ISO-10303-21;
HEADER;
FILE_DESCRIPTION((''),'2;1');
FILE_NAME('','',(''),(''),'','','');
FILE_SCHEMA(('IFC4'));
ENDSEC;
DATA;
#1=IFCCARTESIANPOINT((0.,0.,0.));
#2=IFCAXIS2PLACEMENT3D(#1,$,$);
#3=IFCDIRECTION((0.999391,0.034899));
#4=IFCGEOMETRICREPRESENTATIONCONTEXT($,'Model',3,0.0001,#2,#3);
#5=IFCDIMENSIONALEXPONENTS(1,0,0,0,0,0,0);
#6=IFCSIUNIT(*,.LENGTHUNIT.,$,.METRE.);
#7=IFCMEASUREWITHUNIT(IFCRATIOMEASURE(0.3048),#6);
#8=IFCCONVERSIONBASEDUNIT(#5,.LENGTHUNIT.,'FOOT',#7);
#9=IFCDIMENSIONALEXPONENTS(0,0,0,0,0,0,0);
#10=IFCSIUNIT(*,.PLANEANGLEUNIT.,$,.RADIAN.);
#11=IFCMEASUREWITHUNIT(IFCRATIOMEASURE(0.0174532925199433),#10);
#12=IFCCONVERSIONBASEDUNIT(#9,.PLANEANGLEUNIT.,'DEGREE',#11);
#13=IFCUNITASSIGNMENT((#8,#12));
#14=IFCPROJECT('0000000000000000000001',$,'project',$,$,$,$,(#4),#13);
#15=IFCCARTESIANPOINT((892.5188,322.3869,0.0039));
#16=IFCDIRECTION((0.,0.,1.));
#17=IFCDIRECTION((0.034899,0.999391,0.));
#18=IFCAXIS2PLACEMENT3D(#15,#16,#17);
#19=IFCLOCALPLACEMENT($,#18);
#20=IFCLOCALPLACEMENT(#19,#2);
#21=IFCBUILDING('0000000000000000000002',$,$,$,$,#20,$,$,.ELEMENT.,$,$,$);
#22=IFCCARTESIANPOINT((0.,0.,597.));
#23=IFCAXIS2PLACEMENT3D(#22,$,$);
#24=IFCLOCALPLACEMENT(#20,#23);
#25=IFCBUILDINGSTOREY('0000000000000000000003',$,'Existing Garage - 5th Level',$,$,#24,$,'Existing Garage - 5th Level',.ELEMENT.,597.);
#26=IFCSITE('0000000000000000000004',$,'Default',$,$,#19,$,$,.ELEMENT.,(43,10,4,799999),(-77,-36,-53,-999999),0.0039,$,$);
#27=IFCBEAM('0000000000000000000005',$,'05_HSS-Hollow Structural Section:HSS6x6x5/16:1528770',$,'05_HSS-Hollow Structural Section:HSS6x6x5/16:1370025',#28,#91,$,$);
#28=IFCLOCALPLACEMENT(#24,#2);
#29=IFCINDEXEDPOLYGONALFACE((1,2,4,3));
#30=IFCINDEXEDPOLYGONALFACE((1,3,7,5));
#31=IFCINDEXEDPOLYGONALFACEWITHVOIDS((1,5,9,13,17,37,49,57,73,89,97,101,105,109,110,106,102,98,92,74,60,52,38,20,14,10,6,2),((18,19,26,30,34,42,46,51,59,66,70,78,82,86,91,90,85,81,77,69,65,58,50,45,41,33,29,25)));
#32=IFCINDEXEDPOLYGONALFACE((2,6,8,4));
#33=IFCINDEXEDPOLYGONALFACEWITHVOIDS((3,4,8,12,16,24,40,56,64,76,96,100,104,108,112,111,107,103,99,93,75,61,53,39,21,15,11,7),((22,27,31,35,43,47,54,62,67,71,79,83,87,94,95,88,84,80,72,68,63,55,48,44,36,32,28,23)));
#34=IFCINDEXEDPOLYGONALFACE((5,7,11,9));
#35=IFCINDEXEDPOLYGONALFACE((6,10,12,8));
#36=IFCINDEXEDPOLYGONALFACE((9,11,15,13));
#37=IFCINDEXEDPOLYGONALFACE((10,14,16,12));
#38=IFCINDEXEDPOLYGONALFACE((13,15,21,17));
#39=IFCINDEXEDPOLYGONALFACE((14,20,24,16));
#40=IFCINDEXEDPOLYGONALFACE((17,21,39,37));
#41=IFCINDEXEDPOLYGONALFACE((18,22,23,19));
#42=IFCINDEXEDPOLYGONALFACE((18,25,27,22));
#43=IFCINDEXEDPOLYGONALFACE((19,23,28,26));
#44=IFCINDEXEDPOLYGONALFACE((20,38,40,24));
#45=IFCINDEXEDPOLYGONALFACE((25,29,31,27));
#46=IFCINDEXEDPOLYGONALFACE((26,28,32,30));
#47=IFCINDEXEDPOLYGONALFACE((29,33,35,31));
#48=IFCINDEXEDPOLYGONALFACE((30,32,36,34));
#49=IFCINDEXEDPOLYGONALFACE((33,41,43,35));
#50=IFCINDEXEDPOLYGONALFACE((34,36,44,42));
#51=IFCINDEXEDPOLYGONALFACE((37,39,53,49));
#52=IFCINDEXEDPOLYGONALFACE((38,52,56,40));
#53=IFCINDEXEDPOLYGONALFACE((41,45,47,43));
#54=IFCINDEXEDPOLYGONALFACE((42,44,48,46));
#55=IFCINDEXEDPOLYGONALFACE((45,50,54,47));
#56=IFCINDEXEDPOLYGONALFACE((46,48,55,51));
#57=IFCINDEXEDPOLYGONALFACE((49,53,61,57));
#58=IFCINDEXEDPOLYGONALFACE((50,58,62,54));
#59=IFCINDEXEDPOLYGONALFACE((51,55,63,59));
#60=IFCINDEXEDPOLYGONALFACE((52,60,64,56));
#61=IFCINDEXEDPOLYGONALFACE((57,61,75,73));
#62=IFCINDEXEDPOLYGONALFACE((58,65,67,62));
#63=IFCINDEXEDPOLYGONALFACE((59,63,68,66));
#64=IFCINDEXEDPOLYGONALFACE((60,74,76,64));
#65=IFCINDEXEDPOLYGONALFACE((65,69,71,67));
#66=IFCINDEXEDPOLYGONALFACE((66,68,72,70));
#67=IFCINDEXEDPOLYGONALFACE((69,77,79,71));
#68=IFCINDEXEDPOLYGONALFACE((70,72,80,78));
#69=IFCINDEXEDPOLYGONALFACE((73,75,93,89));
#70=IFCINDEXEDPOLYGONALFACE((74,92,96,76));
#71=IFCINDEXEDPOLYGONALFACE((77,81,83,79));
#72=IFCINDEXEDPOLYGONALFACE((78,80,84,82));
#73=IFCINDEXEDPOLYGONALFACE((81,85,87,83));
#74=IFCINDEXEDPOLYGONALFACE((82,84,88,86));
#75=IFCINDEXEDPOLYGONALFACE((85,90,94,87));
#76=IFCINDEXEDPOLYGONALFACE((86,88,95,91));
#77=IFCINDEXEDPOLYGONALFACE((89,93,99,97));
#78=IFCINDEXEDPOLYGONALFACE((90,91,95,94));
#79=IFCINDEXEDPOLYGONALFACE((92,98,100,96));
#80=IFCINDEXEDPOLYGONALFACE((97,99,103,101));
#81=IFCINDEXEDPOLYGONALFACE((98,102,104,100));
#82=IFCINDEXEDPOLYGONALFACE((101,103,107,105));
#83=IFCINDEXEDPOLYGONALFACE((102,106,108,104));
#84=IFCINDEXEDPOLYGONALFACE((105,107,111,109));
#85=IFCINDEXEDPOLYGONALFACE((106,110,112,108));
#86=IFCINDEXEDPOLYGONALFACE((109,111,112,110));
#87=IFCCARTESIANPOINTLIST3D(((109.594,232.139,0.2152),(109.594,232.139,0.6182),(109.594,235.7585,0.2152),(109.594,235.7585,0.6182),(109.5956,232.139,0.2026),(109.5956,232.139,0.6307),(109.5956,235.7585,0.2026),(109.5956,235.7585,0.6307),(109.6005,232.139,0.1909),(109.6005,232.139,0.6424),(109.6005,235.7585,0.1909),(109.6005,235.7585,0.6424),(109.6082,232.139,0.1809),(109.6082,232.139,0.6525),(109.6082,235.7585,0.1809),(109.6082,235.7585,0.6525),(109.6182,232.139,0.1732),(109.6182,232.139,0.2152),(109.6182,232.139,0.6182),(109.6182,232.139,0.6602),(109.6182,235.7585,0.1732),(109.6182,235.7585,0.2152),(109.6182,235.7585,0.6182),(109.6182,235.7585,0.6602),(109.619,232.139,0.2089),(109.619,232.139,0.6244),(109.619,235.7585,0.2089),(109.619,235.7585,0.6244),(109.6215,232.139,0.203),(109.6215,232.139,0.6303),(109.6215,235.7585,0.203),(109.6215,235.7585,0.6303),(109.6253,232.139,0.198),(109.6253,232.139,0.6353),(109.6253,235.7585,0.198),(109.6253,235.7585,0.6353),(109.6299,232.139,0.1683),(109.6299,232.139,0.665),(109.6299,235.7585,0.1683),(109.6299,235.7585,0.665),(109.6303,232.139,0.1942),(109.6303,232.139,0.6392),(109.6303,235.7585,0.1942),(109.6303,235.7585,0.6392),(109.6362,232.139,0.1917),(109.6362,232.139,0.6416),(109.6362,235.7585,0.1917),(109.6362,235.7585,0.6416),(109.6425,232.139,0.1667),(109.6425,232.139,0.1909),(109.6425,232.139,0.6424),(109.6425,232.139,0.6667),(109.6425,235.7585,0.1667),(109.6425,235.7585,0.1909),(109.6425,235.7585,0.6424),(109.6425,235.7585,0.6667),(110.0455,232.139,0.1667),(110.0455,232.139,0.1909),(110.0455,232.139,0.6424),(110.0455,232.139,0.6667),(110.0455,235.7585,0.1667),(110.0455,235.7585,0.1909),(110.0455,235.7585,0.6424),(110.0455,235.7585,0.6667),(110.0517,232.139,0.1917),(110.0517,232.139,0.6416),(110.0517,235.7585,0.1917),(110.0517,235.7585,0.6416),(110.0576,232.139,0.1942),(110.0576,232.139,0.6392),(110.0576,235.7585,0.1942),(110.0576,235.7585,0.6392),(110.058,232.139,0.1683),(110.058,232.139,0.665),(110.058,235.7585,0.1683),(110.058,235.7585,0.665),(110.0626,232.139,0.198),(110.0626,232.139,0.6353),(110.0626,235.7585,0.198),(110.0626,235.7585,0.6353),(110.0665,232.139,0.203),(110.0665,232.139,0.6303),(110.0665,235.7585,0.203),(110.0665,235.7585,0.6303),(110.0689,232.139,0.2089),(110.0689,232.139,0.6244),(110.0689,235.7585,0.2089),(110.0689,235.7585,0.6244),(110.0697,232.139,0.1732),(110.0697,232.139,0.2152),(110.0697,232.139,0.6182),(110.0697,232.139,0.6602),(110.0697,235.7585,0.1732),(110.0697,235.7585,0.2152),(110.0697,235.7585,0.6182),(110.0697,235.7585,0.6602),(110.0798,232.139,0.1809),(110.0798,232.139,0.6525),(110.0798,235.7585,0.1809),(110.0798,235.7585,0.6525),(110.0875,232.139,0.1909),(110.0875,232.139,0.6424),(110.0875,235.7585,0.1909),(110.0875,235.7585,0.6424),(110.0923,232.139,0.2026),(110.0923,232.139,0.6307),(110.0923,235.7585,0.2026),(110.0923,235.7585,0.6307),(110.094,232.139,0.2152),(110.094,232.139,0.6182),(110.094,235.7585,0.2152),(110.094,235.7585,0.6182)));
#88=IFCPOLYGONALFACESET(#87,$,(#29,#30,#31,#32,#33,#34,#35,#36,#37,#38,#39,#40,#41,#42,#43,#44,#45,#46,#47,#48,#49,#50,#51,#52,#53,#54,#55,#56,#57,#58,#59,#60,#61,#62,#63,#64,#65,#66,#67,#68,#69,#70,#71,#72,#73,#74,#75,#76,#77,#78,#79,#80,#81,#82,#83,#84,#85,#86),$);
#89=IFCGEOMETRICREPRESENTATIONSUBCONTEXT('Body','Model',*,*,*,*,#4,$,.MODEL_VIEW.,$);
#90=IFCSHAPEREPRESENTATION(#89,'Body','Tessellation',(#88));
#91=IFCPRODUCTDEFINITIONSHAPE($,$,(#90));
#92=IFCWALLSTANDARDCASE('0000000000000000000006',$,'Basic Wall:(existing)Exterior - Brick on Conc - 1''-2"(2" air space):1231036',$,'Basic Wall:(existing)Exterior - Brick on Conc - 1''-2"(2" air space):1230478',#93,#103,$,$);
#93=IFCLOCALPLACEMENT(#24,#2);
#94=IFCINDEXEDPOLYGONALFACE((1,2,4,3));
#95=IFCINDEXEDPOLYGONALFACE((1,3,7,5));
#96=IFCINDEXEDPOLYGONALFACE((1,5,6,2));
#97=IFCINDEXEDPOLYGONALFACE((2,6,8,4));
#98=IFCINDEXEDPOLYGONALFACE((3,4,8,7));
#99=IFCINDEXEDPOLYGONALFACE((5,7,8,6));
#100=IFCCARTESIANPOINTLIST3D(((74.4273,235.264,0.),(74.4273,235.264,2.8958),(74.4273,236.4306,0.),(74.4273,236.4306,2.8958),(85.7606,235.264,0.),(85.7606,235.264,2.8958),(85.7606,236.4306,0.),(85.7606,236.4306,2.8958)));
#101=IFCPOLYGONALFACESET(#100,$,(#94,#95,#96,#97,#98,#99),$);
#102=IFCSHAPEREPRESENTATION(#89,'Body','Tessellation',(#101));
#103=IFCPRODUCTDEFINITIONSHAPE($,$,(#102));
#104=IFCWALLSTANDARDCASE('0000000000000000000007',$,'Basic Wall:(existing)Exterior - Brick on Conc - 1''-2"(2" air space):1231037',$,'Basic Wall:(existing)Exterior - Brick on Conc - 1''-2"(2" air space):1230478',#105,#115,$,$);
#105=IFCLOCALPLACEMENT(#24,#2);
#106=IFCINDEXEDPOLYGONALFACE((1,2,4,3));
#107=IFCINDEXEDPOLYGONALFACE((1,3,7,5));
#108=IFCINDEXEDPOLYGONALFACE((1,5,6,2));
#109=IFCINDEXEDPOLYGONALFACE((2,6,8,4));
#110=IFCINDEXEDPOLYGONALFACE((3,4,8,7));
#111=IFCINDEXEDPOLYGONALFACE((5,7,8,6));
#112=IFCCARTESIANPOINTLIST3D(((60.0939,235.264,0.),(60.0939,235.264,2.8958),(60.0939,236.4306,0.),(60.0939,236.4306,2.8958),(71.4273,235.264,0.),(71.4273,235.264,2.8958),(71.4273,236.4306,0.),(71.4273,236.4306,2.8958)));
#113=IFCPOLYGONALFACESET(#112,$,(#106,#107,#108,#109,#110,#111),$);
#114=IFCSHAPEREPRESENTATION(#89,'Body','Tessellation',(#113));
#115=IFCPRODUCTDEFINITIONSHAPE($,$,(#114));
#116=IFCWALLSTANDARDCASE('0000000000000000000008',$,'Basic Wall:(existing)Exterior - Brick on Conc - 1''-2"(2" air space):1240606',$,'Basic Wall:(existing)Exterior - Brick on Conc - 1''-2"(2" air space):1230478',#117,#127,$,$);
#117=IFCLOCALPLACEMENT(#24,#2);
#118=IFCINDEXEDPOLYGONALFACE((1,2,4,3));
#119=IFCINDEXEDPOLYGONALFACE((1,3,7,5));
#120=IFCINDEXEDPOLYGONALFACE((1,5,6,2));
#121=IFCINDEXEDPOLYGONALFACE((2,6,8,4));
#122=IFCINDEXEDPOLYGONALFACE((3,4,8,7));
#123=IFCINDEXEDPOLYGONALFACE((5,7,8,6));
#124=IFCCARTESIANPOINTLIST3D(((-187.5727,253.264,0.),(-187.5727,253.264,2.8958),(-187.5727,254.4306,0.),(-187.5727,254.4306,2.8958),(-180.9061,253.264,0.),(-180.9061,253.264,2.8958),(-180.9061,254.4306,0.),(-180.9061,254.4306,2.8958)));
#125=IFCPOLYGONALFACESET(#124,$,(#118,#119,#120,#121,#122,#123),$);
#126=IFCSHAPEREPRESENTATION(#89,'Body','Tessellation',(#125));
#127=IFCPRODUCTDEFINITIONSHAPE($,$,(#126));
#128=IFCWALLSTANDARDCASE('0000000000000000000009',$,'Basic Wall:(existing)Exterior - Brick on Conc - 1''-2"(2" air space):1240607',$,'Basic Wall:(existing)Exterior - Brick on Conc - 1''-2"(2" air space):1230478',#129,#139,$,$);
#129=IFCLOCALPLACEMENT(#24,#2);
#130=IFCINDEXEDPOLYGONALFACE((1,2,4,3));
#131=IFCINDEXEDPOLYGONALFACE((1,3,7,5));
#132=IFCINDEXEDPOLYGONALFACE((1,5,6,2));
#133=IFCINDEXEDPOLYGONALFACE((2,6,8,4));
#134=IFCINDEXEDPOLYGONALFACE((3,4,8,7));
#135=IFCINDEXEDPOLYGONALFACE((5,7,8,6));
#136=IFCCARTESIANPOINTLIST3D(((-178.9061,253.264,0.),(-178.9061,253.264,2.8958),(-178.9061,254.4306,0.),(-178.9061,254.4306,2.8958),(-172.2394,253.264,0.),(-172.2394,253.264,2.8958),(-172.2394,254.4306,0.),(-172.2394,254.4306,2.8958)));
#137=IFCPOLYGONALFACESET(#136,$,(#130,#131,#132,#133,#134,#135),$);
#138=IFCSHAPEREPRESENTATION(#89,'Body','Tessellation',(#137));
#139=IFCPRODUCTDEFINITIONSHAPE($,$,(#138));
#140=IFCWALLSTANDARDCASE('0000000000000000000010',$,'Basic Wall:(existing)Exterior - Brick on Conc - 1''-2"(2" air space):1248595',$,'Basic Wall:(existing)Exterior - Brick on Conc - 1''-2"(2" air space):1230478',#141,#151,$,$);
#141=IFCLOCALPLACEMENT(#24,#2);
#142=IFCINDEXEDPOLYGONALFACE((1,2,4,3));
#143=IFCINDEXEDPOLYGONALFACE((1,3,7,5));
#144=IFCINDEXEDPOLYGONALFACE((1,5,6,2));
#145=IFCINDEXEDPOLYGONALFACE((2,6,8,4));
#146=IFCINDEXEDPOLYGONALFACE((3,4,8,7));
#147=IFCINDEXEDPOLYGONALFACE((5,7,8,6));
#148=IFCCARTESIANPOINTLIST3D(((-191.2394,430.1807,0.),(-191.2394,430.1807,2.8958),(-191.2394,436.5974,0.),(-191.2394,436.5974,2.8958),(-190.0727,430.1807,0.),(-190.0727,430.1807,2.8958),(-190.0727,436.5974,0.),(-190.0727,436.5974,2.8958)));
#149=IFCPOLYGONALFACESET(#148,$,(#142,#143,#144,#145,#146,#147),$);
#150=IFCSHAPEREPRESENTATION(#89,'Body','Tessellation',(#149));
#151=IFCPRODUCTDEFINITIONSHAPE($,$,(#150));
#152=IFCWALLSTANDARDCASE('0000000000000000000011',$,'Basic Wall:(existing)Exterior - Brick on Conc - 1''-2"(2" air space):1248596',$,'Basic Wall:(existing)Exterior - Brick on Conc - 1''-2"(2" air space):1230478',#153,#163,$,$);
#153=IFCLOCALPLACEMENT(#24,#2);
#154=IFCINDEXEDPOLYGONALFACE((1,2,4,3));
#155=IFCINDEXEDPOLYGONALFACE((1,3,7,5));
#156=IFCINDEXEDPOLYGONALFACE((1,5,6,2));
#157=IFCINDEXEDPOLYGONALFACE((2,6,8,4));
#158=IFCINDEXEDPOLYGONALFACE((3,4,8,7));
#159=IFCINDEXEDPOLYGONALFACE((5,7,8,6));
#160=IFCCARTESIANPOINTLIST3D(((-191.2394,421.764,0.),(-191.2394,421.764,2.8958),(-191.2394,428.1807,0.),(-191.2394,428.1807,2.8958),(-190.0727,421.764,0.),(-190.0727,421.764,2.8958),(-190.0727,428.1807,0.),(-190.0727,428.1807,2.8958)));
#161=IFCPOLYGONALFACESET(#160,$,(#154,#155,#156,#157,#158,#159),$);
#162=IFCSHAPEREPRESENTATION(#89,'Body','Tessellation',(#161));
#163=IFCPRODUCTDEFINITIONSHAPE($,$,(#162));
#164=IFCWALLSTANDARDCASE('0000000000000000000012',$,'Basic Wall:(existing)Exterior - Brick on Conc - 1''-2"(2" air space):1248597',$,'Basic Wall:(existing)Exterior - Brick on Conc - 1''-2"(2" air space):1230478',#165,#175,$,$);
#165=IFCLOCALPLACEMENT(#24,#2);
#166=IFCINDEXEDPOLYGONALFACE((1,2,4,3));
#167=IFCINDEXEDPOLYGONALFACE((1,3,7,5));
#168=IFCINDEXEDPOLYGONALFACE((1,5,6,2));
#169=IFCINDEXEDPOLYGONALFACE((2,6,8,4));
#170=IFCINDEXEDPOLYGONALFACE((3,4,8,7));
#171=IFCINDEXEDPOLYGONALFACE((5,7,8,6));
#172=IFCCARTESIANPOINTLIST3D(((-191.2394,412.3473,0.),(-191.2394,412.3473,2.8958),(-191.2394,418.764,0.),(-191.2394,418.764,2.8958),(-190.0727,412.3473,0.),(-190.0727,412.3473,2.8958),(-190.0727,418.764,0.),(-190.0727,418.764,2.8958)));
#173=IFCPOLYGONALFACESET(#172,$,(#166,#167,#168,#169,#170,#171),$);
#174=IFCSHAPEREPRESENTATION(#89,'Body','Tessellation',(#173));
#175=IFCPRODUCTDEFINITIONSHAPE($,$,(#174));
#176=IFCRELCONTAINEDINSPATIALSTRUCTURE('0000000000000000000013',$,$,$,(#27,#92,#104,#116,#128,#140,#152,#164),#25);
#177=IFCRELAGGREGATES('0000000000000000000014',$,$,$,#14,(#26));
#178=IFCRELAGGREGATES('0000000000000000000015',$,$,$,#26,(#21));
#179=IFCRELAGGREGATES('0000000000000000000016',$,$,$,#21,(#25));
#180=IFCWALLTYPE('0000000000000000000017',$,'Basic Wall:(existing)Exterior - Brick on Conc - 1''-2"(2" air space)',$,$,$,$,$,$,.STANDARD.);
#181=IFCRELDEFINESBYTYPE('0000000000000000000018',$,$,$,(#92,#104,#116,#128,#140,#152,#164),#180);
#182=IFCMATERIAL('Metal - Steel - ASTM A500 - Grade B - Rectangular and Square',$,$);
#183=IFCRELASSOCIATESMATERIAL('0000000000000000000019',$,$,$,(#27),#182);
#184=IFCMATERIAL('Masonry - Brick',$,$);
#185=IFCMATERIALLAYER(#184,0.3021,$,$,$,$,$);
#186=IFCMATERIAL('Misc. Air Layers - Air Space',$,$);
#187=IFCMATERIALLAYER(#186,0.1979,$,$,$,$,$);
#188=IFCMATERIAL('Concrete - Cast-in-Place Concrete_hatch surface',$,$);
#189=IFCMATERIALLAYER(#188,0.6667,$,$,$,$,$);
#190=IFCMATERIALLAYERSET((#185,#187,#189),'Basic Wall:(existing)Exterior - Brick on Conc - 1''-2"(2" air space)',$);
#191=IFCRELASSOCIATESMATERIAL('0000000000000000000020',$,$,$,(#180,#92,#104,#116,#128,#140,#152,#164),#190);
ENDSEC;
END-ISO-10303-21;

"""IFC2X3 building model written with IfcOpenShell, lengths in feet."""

from ifc_helpers import new_model, entity, si_unit, converted_unit, direction, frame, frame_2d, origin, place, context, subcontext, project, spatial, polyline, circle_curve, parameter, trimmed, segment, composite_curve, rectangle, outline, extrude, material, layer, layer_set, layer_usage, type_object, element, save


model = new_model("IFC2X3")

# Units and contexts
model_context = context("Model", 3, precision=0.0001, world=origin(), true_north=direction((0.999391, 0.034899)))
body_context = subcontext(model_context, "Body", "Model", "MODEL_VIEW")
ifc_project = project(units=[converted_unit("LENGTHUNIT", "FOOT", entity("IfcRatioMeasure", 0.3048), si_unit("LENGTHUNIT", "METRE"), dimensions=[1, 0, 0, 0, 0, 0, 0]), converted_unit("PLANEANGLEUNIT", "DEGREE", entity("IfcRatioMeasure", 0.0174532925199433), si_unit("PLANEANGLEUNIT", "RADIAN"), dimensions=[0, 0, 0, 0, 0, 0, 0])], contexts=[model_context])

# Site, building, storey
site_placement = place(None, frame((892.5188, 322.3869, 0.0039), z_axis=(0.0, 0.0, 1.0), x_axis=(0.034899, 0.999391, 0.0)))
site = spatial("IfcSite", under=ifc_project, at=site_placement, Name="Default", CompositionType="ELEMENT", RefLatitude=(43, 10, 4, 799999), RefLongitude=(-77, -36, -53, -999999), RefElevation=0.0039)
building_placement = place(site_placement, origin())
building = spatial("IfcBuilding", under=site, at=building_placement, CompositionType="ELEMENT")
storey_placement = place(building_placement, frame((0.0, 0.0, 597.0)))
storey = spatial("IfcBuildingStorey", under=building, at=storey_placement, Name="Existing Garage - 5th Level", LongName="Existing Garage - 5th Level", CompositionType="ELEMENT", Elevation=597.0)

# Beam
ifc_material_1 = material(Name="Metal - Steel - ASTM A500 - Grade B - Rectangular and Square")
beam_1_placement = place(storey_placement, frame((109.844, 231.8473, 0.6667), z_axis=(0.0, 0.0, 1.0), x_axis=(0.0, 1.0, 0.0)))
element("IfcBeam", 1, at=beam_1_placement, inside=storey, material=ifc_material_1, Name="05_HSS-Hollow Structural Section:HSS6x6x5/16:1528770", ObjectType="05_HSS-Hollow Structural Section:HSS6x6x5/16:1370025", context=body_context, shape_type="SweptSolid", body=[
    extrude(outline(composite_curve([segment(trimmed(circle_curve(frame_2d((-0.2015, -0.2015), x_axis=(1.0, 0.0)), 0.0485), [parameter(180.0)], [parameter(270.0)], True, "PARAMETER"), True, "CONTINUOUS"), segment(polyline([(-0.2015, -0.25), (0.2015, -0.25)]), True, "CONTINUOUS"), segment(trimmed(circle_curve(frame_2d((0.2015, -0.2015), x_axis=(1.0, 0.0)), 0.0485), [parameter(270.0)], [parameter(0.0)], True, "PARAMETER"), True, "CONTINUOUS"), segment(polyline([(0.25, -0.2015), (0.25, 0.2015)]), True, "CONTINUOUS"), segment(trimmed(circle_curve(frame_2d((0.2015, 0.2015), x_axis=(1.0, 0.0)), 0.0485), [parameter(360.0)], [parameter(90.0)], True, "PARAMETER"), True, "CONTINUOUS"), segment(polyline([(0.2015, 0.25), (-0.2015, 0.25)]), True, "CONTINUOUS"), segment(trimmed(circle_curve(frame_2d((-0.2015, 0.2015), x_axis=(1.0, 0.0)), 0.0485), [parameter(90.0)], [parameter(180.0)], True, "PARAMETER"), True, "CONTINUOUS"), segment(polyline([(-0.25, 0.2015), (-0.25, -0.2015)]), True, "CONTINUOUS")], self_intersect=False), holes=[composite_curve([segment(polyline([(0.2015, -0.2257), (-0.2015, -0.2257)]), True, "CONTINUOUS"), segment(trimmed(circle_curve(frame_2d((-0.2015, -0.2015), x_axis=(1.0, 0.0)), 0.0243), [parameter(180.0)], [parameter(270.0)], True, "PARAMETER"), False, "CONTINUOUS"), segment(polyline([(-0.2257, -0.2015), (-0.2257, 0.2015)]), True, "CONTINUOUS"), segment(trimmed(circle_curve(frame_2d((-0.2015, 0.2015), x_axis=(1.0, 0.0)), 0.0243), [parameter(90.0)], [parameter(180.0)], True, "PARAMETER"), False, "CONTINUOUS"), segment(polyline([(-0.2015, 0.2258), (0.2015, 0.2258)]), True, "CONTINUOUS"), segment(trimmed(circle_curve(frame_2d((0.2015, 0.2015), x_axis=(1.0, 0.0)), 0.0243), [parameter(0.0)], [parameter(90.0)], True, "PARAMETER"), False, "CONTINUOUS"), segment(polyline([(0.2258, 0.2015), (0.2258, -0.2015)]), True, "CONTINUOUS"), segment(trimmed(circle_curve(frame_2d((0.2015, -0.2015), x_axis=(1.0, 0.0)), 0.0243), [parameter(270.0)], [parameter(0.0)], True, "PARAMETER"), False, "CONTINUOUS")], self_intersect=False)]), frame((0.2917, 0.0, -0.25), z_axis=(1.0, 0.0, 0.0), x_axis=(0.0, -1.0, 0.0)), (0.0, 0.0, 1.0), 3.6195),
])

# Walls
ifc_material_2 = material(Name="Masonry - Brick")
ifc_layer_1 = layer(ifc_material_2, 0.3021)
ifc_material_3 = material(Name="Misc. Air Layers - Air Space")
ifc_layer_2 = layer(ifc_material_3, 0.1979)
ifc_material_4 = material(Name="Concrete - Cast-in-Place Concrete_hatch surface")
ifc_layer_3 = layer(ifc_material_4, 0.6667)
ifc_layer_set_1 = layer_set([ifc_layer_1, ifc_layer_2, ifc_layer_3], Name="Basic Wall:(existing)Exterior - Brick on Conc - 1'-2\"(2\" air space)")
ifc_layer_usage_1 = layer_usage(ifc_layer_set_1, "AXIS2", "POSITIVE", -0.5833)
wall_type_1 = type_object("IfcWallType", Name="Basic Wall:(existing)Exterior - Brick on Conc - 1'-2\"(2\" air space)", PredefinedType="STANDARD", material=ifc_layer_set_1)
wall_1_placement = place(storey_placement, frame((74.4273, 235.8473, 0.0)))
element("IfcWallStandardCase", 2, at=wall_1_placement, inside=storey, type_object=wall_type_1, material=ifc_layer_usage_1, Name="Basic Wall:(existing)Exterior - Brick on Conc - 1'-2\"(2\" air space):1231036", ObjectType="Basic Wall:(existing)Exterior - Brick on Conc - 1'-2\"(2\" air space):1230478", context=body_context, shape_type="SweptSolid", body=[
    extrude(rectangle(XDim=11.3333, YDim=1.1667, at=frame_2d((5.6667, 0.0), x_axis=(-1.0, 0.0))), origin(), (0.0, 0.0, 1.0), 2.8958),
])
ifc_layer_usage_2 = layer_usage(ifc_layer_set_1, "AXIS2", "POSITIVE", -0.5833)
wall_2_placement = place(storey_placement, frame((60.0939, 235.8473, 0.0)))
element("IfcWallStandardCase", 3, at=wall_2_placement, inside=storey, type_object=wall_type_1, material=ifc_layer_usage_2, Name="Basic Wall:(existing)Exterior - Brick on Conc - 1'-2\"(2\" air space):1231037", ObjectType="Basic Wall:(existing)Exterior - Brick on Conc - 1'-2\"(2\" air space):1230478", context=body_context, shape_type="SweptSolid", body=[
    extrude(rectangle(XDim=11.3334, YDim=1.1667, at=frame_2d((5.6667, 0.0), x_axis=(-1.0, 0.0))), origin(), (0.0, 0.0, 1.0), 2.8958),
])
ifc_layer_usage_3 = layer_usage(ifc_layer_set_1, "AXIS2", "POSITIVE", -0.5833)
wall_3_placement = place(storey_placement, frame((-187.5727, 253.8473, 0.0)))
element("IfcWallStandardCase", 4, at=wall_3_placement, inside=storey, type_object=wall_type_1, material=ifc_layer_usage_3, Name="Basic Wall:(existing)Exterior - Brick on Conc - 1'-2\"(2\" air space):1240606", ObjectType="Basic Wall:(existing)Exterior - Brick on Conc - 1'-2\"(2\" air space):1230478", context=body_context, shape_type="SweptSolid", body=[
    extrude(rectangle(XDim=6.6667, YDim=1.1667, at=frame_2d((3.3333, 0.0), x_axis=(-1.0, 0.0))), origin(), (0.0, 0.0, 1.0), 2.8958),
])
ifc_layer_usage_4 = layer_usage(ifc_layer_set_1, "AXIS2", "POSITIVE", -0.5833)
wall_4_placement = place(storey_placement, frame((-178.9061, 253.8473, 0.0)))
element("IfcWallStandardCase", 5, at=wall_4_placement, inside=storey, type_object=wall_type_1, material=ifc_layer_usage_4, Name="Basic Wall:(existing)Exterior - Brick on Conc - 1'-2\"(2\" air space):1240607", ObjectType="Basic Wall:(existing)Exterior - Brick on Conc - 1'-2\"(2\" air space):1230478", context=body_context, shape_type="SweptSolid", body=[
    extrude(rectangle(XDim=6.6667, YDim=1.1667, at=frame_2d((3.3333, 0.0), x_axis=(-1.0, 0.0))), origin(), (0.0, 0.0, 1.0), 2.8958),
])
ifc_layer_usage_5 = layer_usage(ifc_layer_set_1, "AXIS2", "POSITIVE", -0.5833)
wall_5_placement = place(storey_placement, frame((-190.6561, 436.5974, 0.0), z_axis=(0.0, 0.0, 1.0), x_axis=(0.0, -1.0, 0.0)))
element("IfcWallStandardCase", 6, at=wall_5_placement, inside=storey, type_object=wall_type_1, material=ifc_layer_usage_5, Name="Basic Wall:(existing)Exterior - Brick on Conc - 1'-2\"(2\" air space):1248595", ObjectType="Basic Wall:(existing)Exterior - Brick on Conc - 1'-2\"(2\" air space):1230478", context=body_context, shape_type="SweptSolid", body=[
    extrude(rectangle(XDim=6.4167, YDim=1.1667, at=frame_2d((3.2084, 0.0), x_axis=(-1.0, 0.0))), origin(), (0.0, 0.0, 1.0), 2.8958),
])
ifc_layer_usage_6 = layer_usage(ifc_layer_set_1, "AXIS2", "POSITIVE", -0.5833)
wall_6_placement = place(storey_placement, frame((-190.6561, 428.1807, 0.0), z_axis=(0.0, 0.0, 1.0), x_axis=(0.0, -1.0, 0.0)))
element("IfcWallStandardCase", 7, at=wall_6_placement, inside=storey, type_object=wall_type_1, material=ifc_layer_usage_6, Name="Basic Wall:(existing)Exterior - Brick on Conc - 1'-2\"(2\" air space):1248596", ObjectType="Basic Wall:(existing)Exterior - Brick on Conc - 1'-2\"(2\" air space):1230478", context=body_context, shape_type="SweptSolid", body=[
    extrude(rectangle(XDim=6.4167, YDim=1.1667, at=frame_2d((3.2084, 0.0), x_axis=(-1.0, 0.0))), origin(), (0.0, 0.0, 1.0), 2.8958),
])
ifc_layer_usage_7 = layer_usage(ifc_layer_set_1, "AXIS2", "POSITIVE", -0.5833)
wall_7_placement = place(storey_placement, frame((-190.6561, 418.764, 0.0), z_axis=(0.0, 0.0, 1.0), x_axis=(0.0, -1.0, 0.0)))
element("IfcWallStandardCase", 8, at=wall_7_placement, inside=storey, type_object=wall_type_1, material=ifc_layer_usage_7, Name="Basic Wall:(existing)Exterior - Brick on Conc - 1'-2\"(2\" air space):1248597", ObjectType="Basic Wall:(existing)Exterior - Brick on Conc - 1'-2\"(2\" air space):1230478", context=body_context, shape_type="SweptSolid", body=[
    extrude(rectangle(XDim=6.4167, YDim=1.1667, at=frame_2d((3.2084, 0.0), x_axis=(-1.0, 0.0))), origin(), (0.0, 0.0, 1.0), 2.8958),
])

save(model, "model.ifc")
